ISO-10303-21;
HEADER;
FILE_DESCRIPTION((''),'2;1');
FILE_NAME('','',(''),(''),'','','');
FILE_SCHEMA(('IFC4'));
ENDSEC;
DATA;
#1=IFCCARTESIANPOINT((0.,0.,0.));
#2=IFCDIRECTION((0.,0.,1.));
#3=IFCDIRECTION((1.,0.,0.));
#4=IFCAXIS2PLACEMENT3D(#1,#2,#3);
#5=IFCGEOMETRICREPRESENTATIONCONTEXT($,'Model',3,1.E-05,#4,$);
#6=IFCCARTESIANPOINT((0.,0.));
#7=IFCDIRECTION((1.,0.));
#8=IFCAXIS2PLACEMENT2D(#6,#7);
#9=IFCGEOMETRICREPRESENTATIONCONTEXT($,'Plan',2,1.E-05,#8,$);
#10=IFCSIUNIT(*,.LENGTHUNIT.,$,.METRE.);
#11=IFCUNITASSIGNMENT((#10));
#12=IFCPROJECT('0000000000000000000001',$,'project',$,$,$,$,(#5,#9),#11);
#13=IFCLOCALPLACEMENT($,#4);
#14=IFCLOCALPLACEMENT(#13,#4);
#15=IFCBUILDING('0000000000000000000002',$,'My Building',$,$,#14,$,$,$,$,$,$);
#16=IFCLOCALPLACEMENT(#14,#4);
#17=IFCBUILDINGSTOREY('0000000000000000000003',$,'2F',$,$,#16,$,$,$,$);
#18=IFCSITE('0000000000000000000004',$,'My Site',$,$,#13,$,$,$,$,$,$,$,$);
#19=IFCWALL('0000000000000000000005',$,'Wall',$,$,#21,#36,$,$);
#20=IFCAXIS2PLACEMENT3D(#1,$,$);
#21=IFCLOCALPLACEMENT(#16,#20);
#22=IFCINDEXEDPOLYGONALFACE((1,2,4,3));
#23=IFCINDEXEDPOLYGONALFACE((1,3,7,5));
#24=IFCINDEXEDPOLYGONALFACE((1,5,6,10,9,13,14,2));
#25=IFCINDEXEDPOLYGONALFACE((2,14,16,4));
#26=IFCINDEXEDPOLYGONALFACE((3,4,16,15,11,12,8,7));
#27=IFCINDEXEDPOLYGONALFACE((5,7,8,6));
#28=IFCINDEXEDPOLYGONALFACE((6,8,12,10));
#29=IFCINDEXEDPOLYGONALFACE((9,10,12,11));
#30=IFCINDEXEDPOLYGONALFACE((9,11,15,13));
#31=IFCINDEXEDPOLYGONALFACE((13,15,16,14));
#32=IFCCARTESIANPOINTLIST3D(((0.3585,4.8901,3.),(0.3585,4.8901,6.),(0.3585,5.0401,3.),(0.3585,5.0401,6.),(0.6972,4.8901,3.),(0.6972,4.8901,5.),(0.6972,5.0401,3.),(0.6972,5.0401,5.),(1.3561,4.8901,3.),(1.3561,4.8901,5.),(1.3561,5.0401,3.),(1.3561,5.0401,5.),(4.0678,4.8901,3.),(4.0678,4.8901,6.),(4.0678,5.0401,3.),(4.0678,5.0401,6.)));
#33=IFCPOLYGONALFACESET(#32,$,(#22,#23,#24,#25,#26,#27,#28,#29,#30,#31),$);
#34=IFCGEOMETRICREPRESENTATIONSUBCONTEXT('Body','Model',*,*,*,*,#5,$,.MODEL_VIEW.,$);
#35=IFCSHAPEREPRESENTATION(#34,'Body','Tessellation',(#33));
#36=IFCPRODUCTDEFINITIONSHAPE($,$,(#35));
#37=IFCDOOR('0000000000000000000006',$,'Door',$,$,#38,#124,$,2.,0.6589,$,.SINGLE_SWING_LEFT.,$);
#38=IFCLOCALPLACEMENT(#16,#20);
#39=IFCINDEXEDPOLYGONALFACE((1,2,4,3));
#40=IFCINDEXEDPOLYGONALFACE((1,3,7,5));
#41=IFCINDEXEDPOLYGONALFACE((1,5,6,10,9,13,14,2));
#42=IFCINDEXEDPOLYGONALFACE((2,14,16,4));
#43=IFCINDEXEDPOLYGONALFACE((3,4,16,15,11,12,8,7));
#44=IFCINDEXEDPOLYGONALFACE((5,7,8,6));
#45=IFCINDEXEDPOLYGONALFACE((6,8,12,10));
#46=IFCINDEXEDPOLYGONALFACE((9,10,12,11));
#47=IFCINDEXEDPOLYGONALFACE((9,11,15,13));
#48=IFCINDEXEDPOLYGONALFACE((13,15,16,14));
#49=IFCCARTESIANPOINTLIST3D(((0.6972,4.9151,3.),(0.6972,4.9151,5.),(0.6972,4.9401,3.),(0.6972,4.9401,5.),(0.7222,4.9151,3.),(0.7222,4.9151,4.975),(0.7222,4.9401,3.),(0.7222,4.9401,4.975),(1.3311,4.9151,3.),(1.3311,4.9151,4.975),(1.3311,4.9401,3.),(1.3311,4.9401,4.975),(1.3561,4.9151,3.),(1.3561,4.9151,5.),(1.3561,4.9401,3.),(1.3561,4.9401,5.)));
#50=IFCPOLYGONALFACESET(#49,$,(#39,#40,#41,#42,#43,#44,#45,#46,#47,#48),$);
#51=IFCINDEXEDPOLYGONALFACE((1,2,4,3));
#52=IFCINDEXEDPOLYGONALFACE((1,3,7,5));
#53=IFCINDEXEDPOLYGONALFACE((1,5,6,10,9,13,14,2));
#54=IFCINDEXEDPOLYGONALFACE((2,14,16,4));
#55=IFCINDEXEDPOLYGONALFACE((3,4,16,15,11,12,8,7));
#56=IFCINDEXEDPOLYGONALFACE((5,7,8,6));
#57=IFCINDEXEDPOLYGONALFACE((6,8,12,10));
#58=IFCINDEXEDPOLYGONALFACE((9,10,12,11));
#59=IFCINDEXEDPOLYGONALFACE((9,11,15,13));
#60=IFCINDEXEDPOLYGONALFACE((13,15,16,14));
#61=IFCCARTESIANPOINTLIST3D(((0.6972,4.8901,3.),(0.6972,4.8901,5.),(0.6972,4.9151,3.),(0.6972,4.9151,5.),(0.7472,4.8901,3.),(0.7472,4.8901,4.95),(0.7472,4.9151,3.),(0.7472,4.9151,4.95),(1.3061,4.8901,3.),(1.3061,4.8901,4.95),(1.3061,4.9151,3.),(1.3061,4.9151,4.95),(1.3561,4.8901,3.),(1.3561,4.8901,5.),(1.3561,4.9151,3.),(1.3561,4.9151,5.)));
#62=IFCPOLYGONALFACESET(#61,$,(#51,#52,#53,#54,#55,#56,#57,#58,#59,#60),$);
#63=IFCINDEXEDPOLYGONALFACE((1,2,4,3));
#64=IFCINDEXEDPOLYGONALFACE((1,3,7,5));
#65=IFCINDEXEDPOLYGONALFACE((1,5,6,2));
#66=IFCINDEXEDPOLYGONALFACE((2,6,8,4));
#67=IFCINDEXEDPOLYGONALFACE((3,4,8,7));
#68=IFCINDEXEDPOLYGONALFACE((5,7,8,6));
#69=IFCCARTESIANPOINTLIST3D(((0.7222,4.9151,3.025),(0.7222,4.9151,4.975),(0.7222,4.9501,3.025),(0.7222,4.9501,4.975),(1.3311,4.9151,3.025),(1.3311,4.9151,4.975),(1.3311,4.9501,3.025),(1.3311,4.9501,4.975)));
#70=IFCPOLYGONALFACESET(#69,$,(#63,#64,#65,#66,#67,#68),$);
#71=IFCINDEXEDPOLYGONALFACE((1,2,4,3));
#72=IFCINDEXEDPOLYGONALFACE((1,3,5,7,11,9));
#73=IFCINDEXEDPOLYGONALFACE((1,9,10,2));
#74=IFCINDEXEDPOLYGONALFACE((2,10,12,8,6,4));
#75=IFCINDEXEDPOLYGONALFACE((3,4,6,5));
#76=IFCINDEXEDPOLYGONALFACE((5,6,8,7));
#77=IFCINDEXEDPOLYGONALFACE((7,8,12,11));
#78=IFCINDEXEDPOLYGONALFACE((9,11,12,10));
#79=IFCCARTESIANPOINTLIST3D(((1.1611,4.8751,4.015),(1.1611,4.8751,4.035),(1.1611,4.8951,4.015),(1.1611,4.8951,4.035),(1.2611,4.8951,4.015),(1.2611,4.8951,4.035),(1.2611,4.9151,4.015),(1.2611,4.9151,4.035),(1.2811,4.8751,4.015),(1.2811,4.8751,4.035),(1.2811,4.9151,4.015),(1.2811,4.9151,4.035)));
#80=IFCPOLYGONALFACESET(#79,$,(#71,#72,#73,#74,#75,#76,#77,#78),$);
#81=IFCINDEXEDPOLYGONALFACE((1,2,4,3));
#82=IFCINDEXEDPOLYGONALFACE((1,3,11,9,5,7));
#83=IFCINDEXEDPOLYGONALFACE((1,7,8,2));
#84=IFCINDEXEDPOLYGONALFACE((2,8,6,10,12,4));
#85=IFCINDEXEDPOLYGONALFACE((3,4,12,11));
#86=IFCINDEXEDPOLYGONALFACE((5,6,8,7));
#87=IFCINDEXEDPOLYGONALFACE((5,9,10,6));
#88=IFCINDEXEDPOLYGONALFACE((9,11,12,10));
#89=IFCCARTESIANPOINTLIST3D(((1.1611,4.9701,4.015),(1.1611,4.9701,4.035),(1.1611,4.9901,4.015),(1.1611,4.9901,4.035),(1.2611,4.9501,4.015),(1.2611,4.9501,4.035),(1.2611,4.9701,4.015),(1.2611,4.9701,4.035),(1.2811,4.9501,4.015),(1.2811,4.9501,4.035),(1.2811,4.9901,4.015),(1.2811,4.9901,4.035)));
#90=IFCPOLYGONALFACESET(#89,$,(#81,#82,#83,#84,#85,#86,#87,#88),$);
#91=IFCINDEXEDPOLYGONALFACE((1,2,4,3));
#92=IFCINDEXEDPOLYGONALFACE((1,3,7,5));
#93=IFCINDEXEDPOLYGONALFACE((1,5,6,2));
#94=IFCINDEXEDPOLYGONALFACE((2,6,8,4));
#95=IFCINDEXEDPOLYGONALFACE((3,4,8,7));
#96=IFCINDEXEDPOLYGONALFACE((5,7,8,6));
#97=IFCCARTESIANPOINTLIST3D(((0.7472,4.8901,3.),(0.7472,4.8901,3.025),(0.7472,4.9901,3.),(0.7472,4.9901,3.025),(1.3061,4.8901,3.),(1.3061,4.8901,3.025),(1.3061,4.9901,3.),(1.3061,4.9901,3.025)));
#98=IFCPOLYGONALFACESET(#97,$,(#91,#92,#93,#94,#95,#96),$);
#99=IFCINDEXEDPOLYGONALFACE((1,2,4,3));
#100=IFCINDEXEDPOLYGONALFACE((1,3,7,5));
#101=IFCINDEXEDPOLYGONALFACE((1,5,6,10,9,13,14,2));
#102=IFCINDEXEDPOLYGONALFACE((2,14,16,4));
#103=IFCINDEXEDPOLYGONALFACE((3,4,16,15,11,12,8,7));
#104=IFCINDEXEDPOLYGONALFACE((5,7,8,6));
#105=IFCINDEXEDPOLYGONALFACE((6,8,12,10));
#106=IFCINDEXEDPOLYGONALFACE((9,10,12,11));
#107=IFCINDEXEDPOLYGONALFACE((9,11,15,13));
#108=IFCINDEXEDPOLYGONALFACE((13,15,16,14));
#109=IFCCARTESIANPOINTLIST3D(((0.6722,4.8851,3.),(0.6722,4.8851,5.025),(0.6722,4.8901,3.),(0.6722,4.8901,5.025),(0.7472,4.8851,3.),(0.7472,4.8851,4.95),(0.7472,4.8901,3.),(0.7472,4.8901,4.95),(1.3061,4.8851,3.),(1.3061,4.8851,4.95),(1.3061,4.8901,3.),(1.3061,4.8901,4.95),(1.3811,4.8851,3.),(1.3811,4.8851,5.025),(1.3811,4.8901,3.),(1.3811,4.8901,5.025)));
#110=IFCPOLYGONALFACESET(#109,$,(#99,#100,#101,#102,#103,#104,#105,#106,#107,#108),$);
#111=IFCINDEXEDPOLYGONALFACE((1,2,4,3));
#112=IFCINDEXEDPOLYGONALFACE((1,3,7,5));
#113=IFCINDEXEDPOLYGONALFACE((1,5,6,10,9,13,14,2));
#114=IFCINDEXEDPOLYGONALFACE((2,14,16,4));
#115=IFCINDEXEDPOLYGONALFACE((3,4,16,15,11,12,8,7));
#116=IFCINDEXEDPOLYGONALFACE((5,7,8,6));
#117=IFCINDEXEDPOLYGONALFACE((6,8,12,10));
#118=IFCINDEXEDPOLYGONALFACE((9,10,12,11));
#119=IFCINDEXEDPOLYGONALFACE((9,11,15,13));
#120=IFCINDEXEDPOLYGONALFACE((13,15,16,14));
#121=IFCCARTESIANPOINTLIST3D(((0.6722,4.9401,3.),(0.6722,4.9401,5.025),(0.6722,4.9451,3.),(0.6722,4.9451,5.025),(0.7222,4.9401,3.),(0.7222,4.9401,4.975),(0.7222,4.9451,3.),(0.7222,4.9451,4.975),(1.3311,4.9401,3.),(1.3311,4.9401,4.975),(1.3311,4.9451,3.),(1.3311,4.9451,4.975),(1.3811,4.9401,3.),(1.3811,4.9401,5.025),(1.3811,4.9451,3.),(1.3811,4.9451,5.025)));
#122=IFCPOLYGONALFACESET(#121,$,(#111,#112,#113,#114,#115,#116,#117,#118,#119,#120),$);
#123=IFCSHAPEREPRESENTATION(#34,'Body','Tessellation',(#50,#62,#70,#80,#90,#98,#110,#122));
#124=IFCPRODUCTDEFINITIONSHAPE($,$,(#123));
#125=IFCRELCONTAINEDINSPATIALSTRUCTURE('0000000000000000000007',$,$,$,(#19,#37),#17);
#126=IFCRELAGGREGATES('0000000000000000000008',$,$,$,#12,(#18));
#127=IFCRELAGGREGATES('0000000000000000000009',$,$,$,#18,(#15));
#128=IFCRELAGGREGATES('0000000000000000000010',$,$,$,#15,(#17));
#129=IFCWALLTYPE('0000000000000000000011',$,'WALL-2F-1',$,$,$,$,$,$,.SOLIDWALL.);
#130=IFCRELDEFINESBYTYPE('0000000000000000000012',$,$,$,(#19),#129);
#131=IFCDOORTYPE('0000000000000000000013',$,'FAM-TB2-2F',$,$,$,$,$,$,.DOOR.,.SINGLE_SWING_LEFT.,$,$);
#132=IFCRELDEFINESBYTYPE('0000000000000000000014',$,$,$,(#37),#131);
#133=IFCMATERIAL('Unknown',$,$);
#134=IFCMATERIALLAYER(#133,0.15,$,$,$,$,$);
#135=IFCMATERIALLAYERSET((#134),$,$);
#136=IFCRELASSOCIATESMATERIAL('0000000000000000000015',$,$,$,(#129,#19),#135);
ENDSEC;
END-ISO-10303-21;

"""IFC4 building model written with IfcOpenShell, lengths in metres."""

from ifc_helpers import new_model, entity, si_unit, frame, origin_with_axes, origin_2d_with_axis, place, context, subcontext, project, spatial, line, indexed_curve, outline, extrude, shape, source, transform, mapped, material, layer, layer_set, layer_usage, type_object, type_shapes, element, fill, save


model = new_model("IFC4")

# Units and contexts
model_context = context("Model", 3, precision=1e-05, world=origin_with_axes())
plan_context = context("Plan", 2, precision=1e-05, world=origin_2d_with_axis())
body_context_1 = subcontext(model_context, "Body", "Model", "MODEL_VIEW")
body_context_2 = subcontext(plan_context, "Body", "Plan", "PLAN_VIEW")
ifc_project = project(units=[si_unit("LENGTHUNIT", "METRE")], contexts=[model_context, plan_context])

# Site, building, storey
site_placement = place(None, origin_with_axes())
site = spatial("IfcSite", under=ifc_project, at=site_placement, Name="My Site")
building_placement = place(site_placement, origin_with_axes())
building = spatial("IfcBuilding", under=site, at=building_placement, Name="My Building")
storey_placement = place(building_placement, origin_with_axes())
storey = spatial("IfcBuildingStorey", under=building, at=storey_placement, Name="2F")

# Shared definitions
ifc_material = material(Name="Unknown")

# Shared definitions
ifc_layer_1 = layer(ifc_material, 0.15)
ifc_layer_set_1 = layer_set([ifc_layer_1])
wall_type_1 = type_object("IfcWallType", Name="WALL-2F-1", PredefinedType="SOLIDWALL", material=ifc_layer_set_1)

# Wall, opening, door
ifc_layer_usage_1 = layer_usage(ifc_layer_set_1, "AXIS2", "POSITIVE", 0.0)
wall_1_placement = place(storey_placement, frame((4.2178, 5.0401, 3.0), z_axis=(0.0, 0.0, 1.0), x_axis=(-1.0, 0.0, 0.0)))
wall_1 = element("IfcWall", 1, at=wall_1_placement, inside=storey, type_object=wall_type_1, material=ifc_layer_usage_1, Name="Wall", context=body_context_1, shape_type="SweptSolid", body=[
    extrude(outline(indexed_curve([(0.15, 0.0), (0.15, 0.15), (3.8593, 0.15), (3.8593, 0.0)], segments=[line(1, 2, 3, 4, 1)])), origin_with_axes(), (0.0, 0.0, 1.0), 3.0),
])
shared_shape_1 = source(origin_with_axes(), body_context_1, "Body", "SweptSolid", [
    extrude(outline(indexed_curve([(0.0, 0.0), (0.6589, 0.0), (0.6589, 2.0), (0.0, 2.0)], segments=[line(1, 2, 3, 4, 1)])), frame((0.0, -0.6, 0.0), z_axis=(0.0, -1.0, 0.0), x_axis=(1.0, 0.0, 0.0)), (0.0, 0.0, -1.0), 1.2),
])
opening_1_placement = place(wall_1_placement, frame((3.5206, 0.15, 0.0), z_axis=(0.0, 0.0, 1.0), x_axis=(-1.0, 0.0, 0.0)))
opening_1 = element("IfcOpeningElement", 2, at=opening_1_placement, cuts=wall_1, PredefinedType="OPENING", context=body_context_1, shape_type="MappedRepresentation", body=[
    mapped(shared_shape_1, transform((0.0, 0.0, 0.0), x_axis=(1.0, 0.0, 0.0), y_axis=(0.0, 1.0, 0.0), z_axis=(0.0, 0.0, 1.0), scale=1.0)),
])
door_type_1 = type_object("IfcDoorType", Name="FAM-TB2-2F", OperationType="SINGLE_SWING_LEFT", PredefinedType="DOOR")
shared_shape_2 = source(origin_with_axes(), body_context_1, "Body", "SweptSolid", [
    extrude(outline(indexed_curve([(0.0, 0.0), (0.0, 2.0), (0.6589, 2.0), (0.6589, 0.0), (0.6339, 0.0), (0.6339, 1.975), (0.025, 1.975), (0.025, 0.0)], segments=[line(1, 2, 3, 4, 5, 6, 7, 8, 1)])), frame((0.0, 0.025, 0.0), z_axis=(0.0, -1.0, 0.0), x_axis=(1.0, 0.0, 0.0)), (0.0, 0.0, -1.0), 0.025),
    extrude(outline(indexed_curve([(0.0, 0.0), (0.0, 2.0), (0.6589, 2.0), (0.6589, 0.0), (0.6089, 0.0), (0.6089, 1.95), (0.05, 1.95), (0.05, 0.0)], segments=[line(1, 2, 3, 4, 5, 6, 7, 8, 1)])), frame((0.0, 0.0, 0.0), z_axis=(0.0, -1.0, 0.0), x_axis=(1.0, 0.0, 0.0)), (0.0, 0.0, -1.0), 0.025),
    extrude(outline(indexed_curve([(0.0, 0.0), (0.6089, 0.0), (0.6089, 0.035), (0.0, 0.035)], segments=[line(1, 2, 3, 4, 1)])), frame((0.025, 0.025, 0.025), z_axis=(0.0, 0.0, 1.0), x_axis=(1.0, 0.0, 0.0)), (0.0, 0.0, 1.0), 1.95),
    extrude(outline(indexed_curve([(0.0, 0.0), (0.0, -0.04), (-0.12, -0.04), (-0.12, -0.02), (-0.02, -0.02), (-0.02, 0.0)], segments=[line(1, 2, 3, 4, 5, 6, 1)])), frame((0.5839, 0.025, 1.015), z_axis=(0.0, 0.0, 1.0), x_axis=(1.0, 0.0, 0.0)), (0.0, 0.0, 1.0), 0.02),
    extrude(outline(indexed_curve([(0.0, 0.0), (0.0, 0.04), (-0.12, 0.04), (-0.12, 0.02), (-0.02, 0.02), (-0.02, 0.0)], segments=[line(1, 2, 3, 4, 5, 6, 1)])), frame((0.5839, 0.06, 1.015), z_axis=(0.0, 0.0, 1.0), x_axis=(1.0, 0.0, 0.0)), (0.0, 0.0, 1.0), 0.02),
    extrude(outline(indexed_curve([(0.0, 0.0), (0.5589, 0.0), (0.5589, 0.1), (0.0, 0.1)], segments=[line(1, 2, 3, 4, 1)])), frame((0.05, 0.0, 0.0), z_axis=(0.0, 0.0, 1.0), x_axis=(1.0, 0.0, 0.0)), (0.0, 0.0, 1.0), 0.025),
    extrude(outline(indexed_curve([(0.0, 0.0), (0.0, 2.025), (0.7089, 2.025), (0.7089, 0.0), (0.6339, 0.0), (0.6339, 1.95), (0.075, 1.95), (0.075, 0.0)], segments=[line(1, 2, 3, 4, 5, 6, 7, 8, 1)])), frame((-0.025, -0.005, 0.0), z_axis=(0.0, -1.0, 0.0), x_axis=(1.0, 0.0, 0.0)), (0.0, 0.0, -1.0), 0.005),
    extrude(outline(indexed_curve([(0.0, 0.0), (0.0, 2.025), (0.7089, 2.025), (0.7089, 0.0), (0.6589, 0.0), (0.6589, 1.975), (0.05, 1.975), (0.05, 0.0)], segments=[line(1, 2, 3, 4, 5, 6, 7, 8, 1)])), frame((-0.025, 0.05, 0.0), z_axis=(0.0, -1.0, 0.0), x_axis=(1.0, 0.0, 0.0)), (0.0, 0.0, -1.0), 0.005),
])
shared_shape_3 = source(origin_with_axes(), body_context_2, "Body", "Curve2D", [
    entity("IfcIndexedPolyCurve", entity("IfcCartesianPointList2D", [[0.0, 0.0], [0.0, 0.05], [0.025, 0.05], [0.025, 0.025], [0.05, 0.025], [0.05, 0.0]]), [entity("IfcLineIndex", [1, 2, 3, 4, 5, 6, 1])]),
    entity("IfcIndexedPolyCurve", entity("IfcCartesianPointList2D", [[0.6589, 0.0], [0.6589, 0.05], [0.6339, 0.05], [0.6339, 0.025], [0.6089, 0.025], [0.6089, 0.0]]), [entity("IfcLineIndex", [1, 2, 3, 4, 5, 6, 1])]),
    entity("IfcTrimmedCurve", entity("IfcEllipse", entity("IfcAxis2Placement2D", entity("IfcCartesianPoint", [0.06, 0.05]), entity("IfcDirection", [1.0, 0.0])), 0.5739, 0.6089), [entity("IfcCartesianPoint", [0.6339, 0.05])], [entity("IfcCartesianPoint", [0.06, 0.6589])], True, "CARTESIAN"),
    entity("IfcIndexedPolyCurve", entity("IfcCartesianPointList2D", [[0.025, 0.05], [0.06, 0.05], [0.06, 0.6589], [0.025, 0.6589]]), [entity("IfcLineIndex", [1, 2, 3, 4, 1])]),
])
type_shapes(door_type_1, [shared_shape_2, shared_shape_3])
door_1_placement = place(opening_1_placement, frame((0.0, 0.0, 0.0), z_axis=(0.0, 0.0, 1.0), x_axis=(1.0, 0.0, 0.0)))
door_1 = element("IfcDoor", 3, at=door_1_placement, inside=storey, type_object=door_type_1, Name="Door", OperationType="SINGLE_SWING_LEFT", OverallHeight=2.0, OverallWidth=0.6589, shapes=[
    shape(body_context_1, "Body", "MappedRepresentation", [mapped(shared_shape_2, transform((0.0, 0.0, 0.0), x_axis=(1.0, 0.0, 0.0), y_axis=(0.0, 1.0, 0.0), z_axis=(0.0, 0.0, 1.0), scale=1.0))]),
    shape(body_context_2, "Body", "MappedRepresentation", [mapped(shared_shape_3, transform((0.0, 0.0, 0.0), x_axis=(1.0, 0.0, 0.0), y_axis=(0.0, 1.0, 0.0), z_axis=(0.0, 0.0, 1.0), scale=1.0))]),
])
fill(opening_1, door_1)

save(model, "model.ifc")
